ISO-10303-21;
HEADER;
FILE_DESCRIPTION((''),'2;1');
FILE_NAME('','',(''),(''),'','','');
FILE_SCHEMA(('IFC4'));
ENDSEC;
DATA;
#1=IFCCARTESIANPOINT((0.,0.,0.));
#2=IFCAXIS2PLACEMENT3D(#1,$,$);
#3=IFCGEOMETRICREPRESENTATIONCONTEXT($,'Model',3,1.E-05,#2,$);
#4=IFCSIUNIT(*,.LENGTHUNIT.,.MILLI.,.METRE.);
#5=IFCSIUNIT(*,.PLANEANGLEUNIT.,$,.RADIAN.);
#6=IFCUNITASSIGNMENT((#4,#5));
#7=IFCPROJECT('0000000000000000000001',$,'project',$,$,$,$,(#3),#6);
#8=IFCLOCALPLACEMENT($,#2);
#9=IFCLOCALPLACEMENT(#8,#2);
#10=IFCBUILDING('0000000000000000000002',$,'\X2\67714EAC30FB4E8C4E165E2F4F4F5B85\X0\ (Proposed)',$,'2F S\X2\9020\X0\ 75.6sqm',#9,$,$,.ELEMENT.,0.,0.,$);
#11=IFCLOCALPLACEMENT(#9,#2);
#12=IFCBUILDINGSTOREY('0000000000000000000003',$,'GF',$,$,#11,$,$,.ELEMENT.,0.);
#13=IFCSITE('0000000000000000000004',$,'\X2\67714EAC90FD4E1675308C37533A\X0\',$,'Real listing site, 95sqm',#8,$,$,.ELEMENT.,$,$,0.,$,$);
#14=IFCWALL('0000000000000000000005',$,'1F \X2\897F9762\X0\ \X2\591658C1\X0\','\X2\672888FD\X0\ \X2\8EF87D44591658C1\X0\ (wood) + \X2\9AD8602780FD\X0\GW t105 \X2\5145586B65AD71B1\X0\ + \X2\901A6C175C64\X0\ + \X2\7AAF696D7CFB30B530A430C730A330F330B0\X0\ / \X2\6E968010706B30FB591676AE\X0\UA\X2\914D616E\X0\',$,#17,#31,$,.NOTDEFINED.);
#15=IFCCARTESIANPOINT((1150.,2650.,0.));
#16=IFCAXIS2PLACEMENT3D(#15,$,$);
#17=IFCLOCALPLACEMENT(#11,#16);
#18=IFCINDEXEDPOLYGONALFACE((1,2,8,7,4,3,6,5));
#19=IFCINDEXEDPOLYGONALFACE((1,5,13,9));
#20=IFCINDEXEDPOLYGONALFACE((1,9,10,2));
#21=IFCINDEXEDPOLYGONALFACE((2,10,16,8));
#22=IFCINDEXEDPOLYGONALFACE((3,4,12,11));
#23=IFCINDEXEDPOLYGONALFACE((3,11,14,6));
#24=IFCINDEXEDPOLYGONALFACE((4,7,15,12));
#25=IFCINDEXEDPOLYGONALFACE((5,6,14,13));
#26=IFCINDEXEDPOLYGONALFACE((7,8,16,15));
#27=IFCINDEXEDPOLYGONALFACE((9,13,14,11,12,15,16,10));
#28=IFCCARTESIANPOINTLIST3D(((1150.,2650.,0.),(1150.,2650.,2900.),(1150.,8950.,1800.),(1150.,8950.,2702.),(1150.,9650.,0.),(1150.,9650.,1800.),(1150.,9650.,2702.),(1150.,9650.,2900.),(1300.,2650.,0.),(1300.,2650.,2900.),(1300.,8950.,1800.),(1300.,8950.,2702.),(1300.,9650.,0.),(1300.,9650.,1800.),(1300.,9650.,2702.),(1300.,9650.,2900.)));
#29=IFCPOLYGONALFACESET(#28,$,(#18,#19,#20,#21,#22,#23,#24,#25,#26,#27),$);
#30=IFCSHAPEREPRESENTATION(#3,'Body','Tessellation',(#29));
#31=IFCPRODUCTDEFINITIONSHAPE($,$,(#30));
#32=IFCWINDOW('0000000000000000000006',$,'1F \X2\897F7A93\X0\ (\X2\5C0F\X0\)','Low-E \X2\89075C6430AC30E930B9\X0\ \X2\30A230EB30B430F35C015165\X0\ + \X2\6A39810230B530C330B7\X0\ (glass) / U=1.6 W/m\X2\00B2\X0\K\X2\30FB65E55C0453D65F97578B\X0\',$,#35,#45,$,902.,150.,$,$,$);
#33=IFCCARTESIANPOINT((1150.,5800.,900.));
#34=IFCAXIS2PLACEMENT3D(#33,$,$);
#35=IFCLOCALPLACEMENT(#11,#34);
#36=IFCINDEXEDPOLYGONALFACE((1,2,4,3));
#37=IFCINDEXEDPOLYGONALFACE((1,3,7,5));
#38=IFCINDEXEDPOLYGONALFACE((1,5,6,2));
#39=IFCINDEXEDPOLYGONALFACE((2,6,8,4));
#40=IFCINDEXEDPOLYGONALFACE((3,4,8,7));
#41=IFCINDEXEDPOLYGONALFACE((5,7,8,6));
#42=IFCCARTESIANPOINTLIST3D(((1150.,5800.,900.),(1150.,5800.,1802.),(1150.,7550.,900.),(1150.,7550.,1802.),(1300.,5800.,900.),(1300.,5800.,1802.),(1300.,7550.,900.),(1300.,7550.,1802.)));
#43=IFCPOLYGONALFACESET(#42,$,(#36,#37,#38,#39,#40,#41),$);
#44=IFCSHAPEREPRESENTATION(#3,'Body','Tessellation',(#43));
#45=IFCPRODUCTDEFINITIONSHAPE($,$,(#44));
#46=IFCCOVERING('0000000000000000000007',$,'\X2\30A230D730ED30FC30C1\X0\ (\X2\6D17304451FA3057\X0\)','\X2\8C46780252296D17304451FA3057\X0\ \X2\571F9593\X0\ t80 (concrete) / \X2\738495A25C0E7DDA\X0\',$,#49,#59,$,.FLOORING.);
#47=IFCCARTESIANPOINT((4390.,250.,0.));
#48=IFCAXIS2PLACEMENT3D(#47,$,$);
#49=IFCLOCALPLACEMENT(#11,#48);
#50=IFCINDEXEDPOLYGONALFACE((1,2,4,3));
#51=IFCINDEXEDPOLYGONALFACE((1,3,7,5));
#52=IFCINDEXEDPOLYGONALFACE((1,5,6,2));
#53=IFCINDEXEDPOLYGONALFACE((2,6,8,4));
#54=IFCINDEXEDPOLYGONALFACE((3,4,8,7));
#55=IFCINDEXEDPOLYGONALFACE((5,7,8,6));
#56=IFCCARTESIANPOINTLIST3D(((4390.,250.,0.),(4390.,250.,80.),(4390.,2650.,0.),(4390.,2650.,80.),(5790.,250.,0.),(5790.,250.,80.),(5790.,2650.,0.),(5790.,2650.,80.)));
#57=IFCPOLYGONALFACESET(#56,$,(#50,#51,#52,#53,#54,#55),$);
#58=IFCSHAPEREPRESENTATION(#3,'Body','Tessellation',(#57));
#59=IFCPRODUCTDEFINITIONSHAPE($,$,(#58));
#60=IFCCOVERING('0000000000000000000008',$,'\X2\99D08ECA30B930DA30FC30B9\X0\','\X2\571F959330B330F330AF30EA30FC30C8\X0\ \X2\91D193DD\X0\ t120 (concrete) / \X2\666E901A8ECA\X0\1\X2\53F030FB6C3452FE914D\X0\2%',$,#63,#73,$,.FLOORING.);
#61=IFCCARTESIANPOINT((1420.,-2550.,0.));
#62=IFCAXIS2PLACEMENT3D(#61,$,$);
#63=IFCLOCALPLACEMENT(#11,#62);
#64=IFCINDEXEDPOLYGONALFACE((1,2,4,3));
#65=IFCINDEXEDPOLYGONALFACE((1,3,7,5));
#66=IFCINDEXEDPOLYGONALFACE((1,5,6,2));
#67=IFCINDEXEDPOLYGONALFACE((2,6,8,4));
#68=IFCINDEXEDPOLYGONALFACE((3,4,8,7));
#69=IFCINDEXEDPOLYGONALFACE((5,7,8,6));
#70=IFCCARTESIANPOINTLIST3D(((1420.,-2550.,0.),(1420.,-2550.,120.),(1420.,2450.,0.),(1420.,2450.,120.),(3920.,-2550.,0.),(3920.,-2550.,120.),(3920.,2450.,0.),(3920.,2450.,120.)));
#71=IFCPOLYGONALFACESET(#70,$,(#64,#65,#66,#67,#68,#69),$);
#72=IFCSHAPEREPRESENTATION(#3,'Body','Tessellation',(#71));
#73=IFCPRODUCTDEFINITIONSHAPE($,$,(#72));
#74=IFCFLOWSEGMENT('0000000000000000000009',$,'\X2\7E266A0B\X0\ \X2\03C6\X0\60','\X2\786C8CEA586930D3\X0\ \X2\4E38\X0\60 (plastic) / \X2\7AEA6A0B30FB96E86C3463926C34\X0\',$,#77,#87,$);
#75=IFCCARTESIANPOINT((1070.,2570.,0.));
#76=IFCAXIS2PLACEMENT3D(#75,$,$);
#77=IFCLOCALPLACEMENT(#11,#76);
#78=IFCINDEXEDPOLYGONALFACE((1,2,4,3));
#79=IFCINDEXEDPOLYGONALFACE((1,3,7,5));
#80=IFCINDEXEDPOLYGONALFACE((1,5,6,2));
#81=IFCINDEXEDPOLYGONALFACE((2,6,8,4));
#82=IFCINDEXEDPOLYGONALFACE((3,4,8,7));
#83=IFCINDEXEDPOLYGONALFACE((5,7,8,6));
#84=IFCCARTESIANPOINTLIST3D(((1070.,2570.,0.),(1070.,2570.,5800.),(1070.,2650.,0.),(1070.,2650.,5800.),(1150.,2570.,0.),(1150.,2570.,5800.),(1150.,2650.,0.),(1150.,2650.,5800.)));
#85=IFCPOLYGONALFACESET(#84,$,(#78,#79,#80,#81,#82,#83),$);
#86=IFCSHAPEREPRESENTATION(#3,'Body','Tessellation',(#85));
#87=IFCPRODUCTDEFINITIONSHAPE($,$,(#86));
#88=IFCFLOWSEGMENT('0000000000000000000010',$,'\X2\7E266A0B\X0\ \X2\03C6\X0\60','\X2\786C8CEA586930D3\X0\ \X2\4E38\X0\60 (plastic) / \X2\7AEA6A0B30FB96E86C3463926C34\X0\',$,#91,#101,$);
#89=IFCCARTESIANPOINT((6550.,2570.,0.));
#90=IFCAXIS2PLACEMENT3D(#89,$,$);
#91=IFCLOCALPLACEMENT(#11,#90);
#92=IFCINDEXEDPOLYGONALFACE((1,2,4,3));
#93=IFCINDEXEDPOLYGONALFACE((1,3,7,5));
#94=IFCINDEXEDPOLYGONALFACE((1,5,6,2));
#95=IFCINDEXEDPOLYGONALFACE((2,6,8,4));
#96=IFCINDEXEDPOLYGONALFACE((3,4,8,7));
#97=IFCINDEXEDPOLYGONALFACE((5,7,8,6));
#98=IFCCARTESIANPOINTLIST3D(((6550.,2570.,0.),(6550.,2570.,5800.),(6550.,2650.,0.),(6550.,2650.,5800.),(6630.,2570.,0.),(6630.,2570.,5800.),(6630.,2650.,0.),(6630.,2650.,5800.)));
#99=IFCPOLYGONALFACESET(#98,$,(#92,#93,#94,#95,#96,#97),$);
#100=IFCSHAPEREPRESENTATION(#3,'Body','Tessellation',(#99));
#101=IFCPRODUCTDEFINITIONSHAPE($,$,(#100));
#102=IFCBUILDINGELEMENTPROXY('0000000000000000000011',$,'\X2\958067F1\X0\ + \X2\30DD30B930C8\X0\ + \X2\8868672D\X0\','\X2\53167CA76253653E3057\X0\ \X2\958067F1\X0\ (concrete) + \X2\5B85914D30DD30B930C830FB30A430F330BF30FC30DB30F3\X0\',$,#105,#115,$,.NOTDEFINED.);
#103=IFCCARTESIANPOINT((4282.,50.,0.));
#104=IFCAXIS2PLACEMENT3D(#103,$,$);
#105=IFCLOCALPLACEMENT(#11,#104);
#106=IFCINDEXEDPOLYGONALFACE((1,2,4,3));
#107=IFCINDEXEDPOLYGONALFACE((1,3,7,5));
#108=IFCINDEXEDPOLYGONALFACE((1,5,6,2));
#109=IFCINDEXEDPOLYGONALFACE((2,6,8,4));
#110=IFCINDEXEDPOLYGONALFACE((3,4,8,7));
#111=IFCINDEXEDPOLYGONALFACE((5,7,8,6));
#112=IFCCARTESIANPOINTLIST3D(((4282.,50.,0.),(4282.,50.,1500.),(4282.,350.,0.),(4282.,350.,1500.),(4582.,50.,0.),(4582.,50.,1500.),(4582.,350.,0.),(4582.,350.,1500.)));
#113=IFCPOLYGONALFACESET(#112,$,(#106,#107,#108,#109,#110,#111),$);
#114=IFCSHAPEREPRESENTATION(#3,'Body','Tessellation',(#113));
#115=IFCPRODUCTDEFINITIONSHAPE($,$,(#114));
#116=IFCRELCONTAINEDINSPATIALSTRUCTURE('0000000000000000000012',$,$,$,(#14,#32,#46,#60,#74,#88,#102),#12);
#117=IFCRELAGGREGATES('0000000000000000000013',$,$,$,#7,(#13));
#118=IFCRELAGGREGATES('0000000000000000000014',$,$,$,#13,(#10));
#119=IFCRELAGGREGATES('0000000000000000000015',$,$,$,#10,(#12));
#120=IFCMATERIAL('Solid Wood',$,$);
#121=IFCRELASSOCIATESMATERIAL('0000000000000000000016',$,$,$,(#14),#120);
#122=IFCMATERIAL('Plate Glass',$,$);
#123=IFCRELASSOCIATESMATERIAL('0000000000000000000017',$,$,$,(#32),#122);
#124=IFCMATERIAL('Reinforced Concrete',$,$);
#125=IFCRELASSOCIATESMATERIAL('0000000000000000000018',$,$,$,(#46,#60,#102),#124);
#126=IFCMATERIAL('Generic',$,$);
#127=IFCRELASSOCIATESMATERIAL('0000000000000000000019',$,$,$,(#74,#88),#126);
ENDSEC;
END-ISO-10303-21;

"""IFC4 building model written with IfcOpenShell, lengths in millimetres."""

from ifc_helpers import new_model, si_unit, frame, frame_2d, origin, place, context, project, spatial, rectangle, extrude, material, element, fill, save


model = new_model("IFC4")

# Units and contexts
model_context = context("Model", 3, precision=1e-05, world=origin())
ifc_project = project(units=[si_unit("LENGTHUNIT", "METRE", prefix="MILLI"), si_unit("PLANEANGLEUNIT", "RADIAN")], contexts=[model_context])

# Site, building, storey
site_placement = place(None, origin())
site = spatial("IfcSite", under=ifc_project, at=site_placement, Name="東京都世田谷区", ObjectType="Real listing site, 95sqm", CompositionType="ELEMENT", RefElevation=0.0)
building_placement = place(site_placement, origin())
building = spatial("IfcBuilding", under=site, at=building_placement, Name="東京・二世帯住宅 (Proposed)", ObjectType="2F S造 75.6sqm", CompositionType="ELEMENT", ElevationOfRefHeight=0.0, ElevationOfTerrain=0.0)
storey_placement = place(building_placement, origin())
storey = spatial("IfcBuildingStorey", under=building, at=storey_placement, Name="GF", CompositionType="ELEMENT", Elevation=0.0)

# Shared definitions
ifc_material_1 = material(Name="Solid Wood")

# Shared definitions
ifc_material_2 = material(Name="Reinforced Concrete")

# Shared definitions
ifc_material_3 = material(Name="Plate Glass")

# Wall, opening, window
wall_1_placement = place(storey_placement, frame((1150.0, 2650.0, 0.0)))
wall_1 = element("IfcWall", 1, at=wall_1_placement, inside=storey, material=ifc_material_1, Name="1F 西面 外壁", Description="木製 軸組外壁 (wood) + 高性能GW t105 充填断熱 + 通気層 + 窯業系サイディング / 準耐火・外皮UA配慮", PredefinedType="NOTDEFINED", context=model_context, shape_type="SweptSolid", body=[
    extrude(rectangle(XDim=150.0, YDim=7000.0, at=frame_2d((75.0, 3500.0))), frame((1150.0, 2650.0, 0.0)), (0.0, 0.0, 1.0), 2900.0),
])
opening_1_placement = place(storey_placement, frame((1150.0, 5800.0, 900.0)))
opening_1 = element("IfcOpeningElement", 2, at=opening_1_placement, cuts=wall_1, PredefinedType="NOTDEFINED", context=model_context, shape_type="SweptSolid", body=[
    extrude(rectangle(XDim=150.0, YDim=1750.0, at=frame_2d((75.0, 875.0))), frame((1150.0, 5800.0, 900.0)), (0.0, 0.0, 1.0), 902.0),
])
window_1_placement = place(storey_placement, frame((1150.0, 5800.0, 900.0)))
window_1 = element("IfcWindow", 3, at=window_1_placement, inside=storey, material=ifc_material_3, Name="1F 西窓 (小)", Description="Low-E 複層ガラス アルゴン封入 + 樹脂サッシ (glass) / U=1.6 W/m²K・日射取得型", OverallHeight=902.0, OverallWidth=150.0, context=model_context, shape_type="SweptSolid", body=[
    extrude(rectangle(XDim=150.0, YDim=1750.0, at=frame_2d((75.0, 875.0))), frame((1150.0, 5800.0, 900.0)), (0.0, 0.0, 1.0), 902.0),
])
fill(opening_1, window_1)

# Coverings
covering_1_placement = place(storey_placement, frame((4390.0, 250.0, 0.0)))
element("IfcCovering", 4, at=covering_1_placement, inside=storey, material=ifc_material_2, Name="アプローチ (洗い出し)", Description="豆砂利洗い出し 土間 t80 (concrete) / 玄関導線", PredefinedType="FLOORING", context=model_context, shape_type="SweptSolid", body=[
    extrude(rectangle(XDim=1400.0, YDim=2400.0, at=frame_2d((700.0, 1200.0))), frame((4390.0, 250.0, 0.0)), (0.0, 0.0, 1.0), 80.0),
])
covering_2_placement = place(storey_placement, frame((1420.0, -2550.0, 0.0)))
element("IfcCovering", 5, at=covering_2_placement, inside=storey, material=ifc_material_2, Name="駐車スペース", Description="土間コンクリート 金鏝 t120 (concrete) / 普通車1台・水勾配2%", PredefinedType="FLOORING", context=model_context, shape_type="SweptSolid", body=[
    extrude(rectangle(XDim=2500.0, YDim=5000.0, at=frame_2d((1250.0, 2500.0))), frame((1420.0, -2550.0, 0.0)), (0.0, 0.0, 1.0), 120.0),
])

# Flow segments
ifc_material_4 = material(Name="Generic")
flow_segment_1_placement = place(storey_placement, frame((1070.0, 2570.0, 0.0)))
element("IfcFlowSegment", 6, at=flow_segment_1_placement, inside=storey, material=ifc_material_4, Name="縦樋 φ60", Description="硬質塩ビ 丸60 (plastic) / 竪樋・雨水排水", context=model_context, shape_type="SweptSolid", body=[
    extrude(rectangle(XDim=80.0, YDim=80.0, at=frame_2d((40.0, 40.0))), frame((1070.0, 2570.0, 0.0)), (0.0, 0.0, 1.0), 5800.0),
])
flow_segment_2_placement = place(storey_placement, frame((6550.0, 2570.0, 0.0)))
element("IfcFlowSegment", 7, at=flow_segment_2_placement, inside=storey, material=ifc_material_4, Name="縦樋 φ60", Description="硬質塩ビ 丸60 (plastic) / 竪樋・雨水排水", context=model_context, shape_type="SweptSolid", body=[
    extrude(rectangle(XDim=80.0, YDim=80.0, at=frame_2d((40.0, 40.0))), frame((6550.0, 2570.0, 0.0)), (0.0, 0.0, 1.0), 5800.0),
])

# Building element proxy
proxy_placement = place(storey_placement, frame((4282.0, 50.0, 0.0)))
element("IfcBuildingElementProxy", 8, at=proxy_placement, inside=storey, material=ifc_material_2, Name="門柱 + ポスト + 表札", Description="化粧打放し 門柱 (concrete) + 宅配ポスト・インターホン", PredefinedType="NOTDEFINED", context=model_context, shape_type="SweptSolid", body=[
    extrude(rectangle(XDim=300.0, YDim=300.0, at=frame_2d((150.0, 150.0))), frame((4282.0, 50.0, 0.0)), (0.0, 0.0, 1.0), 1500.0),
])

save(model, "model.ifc")
